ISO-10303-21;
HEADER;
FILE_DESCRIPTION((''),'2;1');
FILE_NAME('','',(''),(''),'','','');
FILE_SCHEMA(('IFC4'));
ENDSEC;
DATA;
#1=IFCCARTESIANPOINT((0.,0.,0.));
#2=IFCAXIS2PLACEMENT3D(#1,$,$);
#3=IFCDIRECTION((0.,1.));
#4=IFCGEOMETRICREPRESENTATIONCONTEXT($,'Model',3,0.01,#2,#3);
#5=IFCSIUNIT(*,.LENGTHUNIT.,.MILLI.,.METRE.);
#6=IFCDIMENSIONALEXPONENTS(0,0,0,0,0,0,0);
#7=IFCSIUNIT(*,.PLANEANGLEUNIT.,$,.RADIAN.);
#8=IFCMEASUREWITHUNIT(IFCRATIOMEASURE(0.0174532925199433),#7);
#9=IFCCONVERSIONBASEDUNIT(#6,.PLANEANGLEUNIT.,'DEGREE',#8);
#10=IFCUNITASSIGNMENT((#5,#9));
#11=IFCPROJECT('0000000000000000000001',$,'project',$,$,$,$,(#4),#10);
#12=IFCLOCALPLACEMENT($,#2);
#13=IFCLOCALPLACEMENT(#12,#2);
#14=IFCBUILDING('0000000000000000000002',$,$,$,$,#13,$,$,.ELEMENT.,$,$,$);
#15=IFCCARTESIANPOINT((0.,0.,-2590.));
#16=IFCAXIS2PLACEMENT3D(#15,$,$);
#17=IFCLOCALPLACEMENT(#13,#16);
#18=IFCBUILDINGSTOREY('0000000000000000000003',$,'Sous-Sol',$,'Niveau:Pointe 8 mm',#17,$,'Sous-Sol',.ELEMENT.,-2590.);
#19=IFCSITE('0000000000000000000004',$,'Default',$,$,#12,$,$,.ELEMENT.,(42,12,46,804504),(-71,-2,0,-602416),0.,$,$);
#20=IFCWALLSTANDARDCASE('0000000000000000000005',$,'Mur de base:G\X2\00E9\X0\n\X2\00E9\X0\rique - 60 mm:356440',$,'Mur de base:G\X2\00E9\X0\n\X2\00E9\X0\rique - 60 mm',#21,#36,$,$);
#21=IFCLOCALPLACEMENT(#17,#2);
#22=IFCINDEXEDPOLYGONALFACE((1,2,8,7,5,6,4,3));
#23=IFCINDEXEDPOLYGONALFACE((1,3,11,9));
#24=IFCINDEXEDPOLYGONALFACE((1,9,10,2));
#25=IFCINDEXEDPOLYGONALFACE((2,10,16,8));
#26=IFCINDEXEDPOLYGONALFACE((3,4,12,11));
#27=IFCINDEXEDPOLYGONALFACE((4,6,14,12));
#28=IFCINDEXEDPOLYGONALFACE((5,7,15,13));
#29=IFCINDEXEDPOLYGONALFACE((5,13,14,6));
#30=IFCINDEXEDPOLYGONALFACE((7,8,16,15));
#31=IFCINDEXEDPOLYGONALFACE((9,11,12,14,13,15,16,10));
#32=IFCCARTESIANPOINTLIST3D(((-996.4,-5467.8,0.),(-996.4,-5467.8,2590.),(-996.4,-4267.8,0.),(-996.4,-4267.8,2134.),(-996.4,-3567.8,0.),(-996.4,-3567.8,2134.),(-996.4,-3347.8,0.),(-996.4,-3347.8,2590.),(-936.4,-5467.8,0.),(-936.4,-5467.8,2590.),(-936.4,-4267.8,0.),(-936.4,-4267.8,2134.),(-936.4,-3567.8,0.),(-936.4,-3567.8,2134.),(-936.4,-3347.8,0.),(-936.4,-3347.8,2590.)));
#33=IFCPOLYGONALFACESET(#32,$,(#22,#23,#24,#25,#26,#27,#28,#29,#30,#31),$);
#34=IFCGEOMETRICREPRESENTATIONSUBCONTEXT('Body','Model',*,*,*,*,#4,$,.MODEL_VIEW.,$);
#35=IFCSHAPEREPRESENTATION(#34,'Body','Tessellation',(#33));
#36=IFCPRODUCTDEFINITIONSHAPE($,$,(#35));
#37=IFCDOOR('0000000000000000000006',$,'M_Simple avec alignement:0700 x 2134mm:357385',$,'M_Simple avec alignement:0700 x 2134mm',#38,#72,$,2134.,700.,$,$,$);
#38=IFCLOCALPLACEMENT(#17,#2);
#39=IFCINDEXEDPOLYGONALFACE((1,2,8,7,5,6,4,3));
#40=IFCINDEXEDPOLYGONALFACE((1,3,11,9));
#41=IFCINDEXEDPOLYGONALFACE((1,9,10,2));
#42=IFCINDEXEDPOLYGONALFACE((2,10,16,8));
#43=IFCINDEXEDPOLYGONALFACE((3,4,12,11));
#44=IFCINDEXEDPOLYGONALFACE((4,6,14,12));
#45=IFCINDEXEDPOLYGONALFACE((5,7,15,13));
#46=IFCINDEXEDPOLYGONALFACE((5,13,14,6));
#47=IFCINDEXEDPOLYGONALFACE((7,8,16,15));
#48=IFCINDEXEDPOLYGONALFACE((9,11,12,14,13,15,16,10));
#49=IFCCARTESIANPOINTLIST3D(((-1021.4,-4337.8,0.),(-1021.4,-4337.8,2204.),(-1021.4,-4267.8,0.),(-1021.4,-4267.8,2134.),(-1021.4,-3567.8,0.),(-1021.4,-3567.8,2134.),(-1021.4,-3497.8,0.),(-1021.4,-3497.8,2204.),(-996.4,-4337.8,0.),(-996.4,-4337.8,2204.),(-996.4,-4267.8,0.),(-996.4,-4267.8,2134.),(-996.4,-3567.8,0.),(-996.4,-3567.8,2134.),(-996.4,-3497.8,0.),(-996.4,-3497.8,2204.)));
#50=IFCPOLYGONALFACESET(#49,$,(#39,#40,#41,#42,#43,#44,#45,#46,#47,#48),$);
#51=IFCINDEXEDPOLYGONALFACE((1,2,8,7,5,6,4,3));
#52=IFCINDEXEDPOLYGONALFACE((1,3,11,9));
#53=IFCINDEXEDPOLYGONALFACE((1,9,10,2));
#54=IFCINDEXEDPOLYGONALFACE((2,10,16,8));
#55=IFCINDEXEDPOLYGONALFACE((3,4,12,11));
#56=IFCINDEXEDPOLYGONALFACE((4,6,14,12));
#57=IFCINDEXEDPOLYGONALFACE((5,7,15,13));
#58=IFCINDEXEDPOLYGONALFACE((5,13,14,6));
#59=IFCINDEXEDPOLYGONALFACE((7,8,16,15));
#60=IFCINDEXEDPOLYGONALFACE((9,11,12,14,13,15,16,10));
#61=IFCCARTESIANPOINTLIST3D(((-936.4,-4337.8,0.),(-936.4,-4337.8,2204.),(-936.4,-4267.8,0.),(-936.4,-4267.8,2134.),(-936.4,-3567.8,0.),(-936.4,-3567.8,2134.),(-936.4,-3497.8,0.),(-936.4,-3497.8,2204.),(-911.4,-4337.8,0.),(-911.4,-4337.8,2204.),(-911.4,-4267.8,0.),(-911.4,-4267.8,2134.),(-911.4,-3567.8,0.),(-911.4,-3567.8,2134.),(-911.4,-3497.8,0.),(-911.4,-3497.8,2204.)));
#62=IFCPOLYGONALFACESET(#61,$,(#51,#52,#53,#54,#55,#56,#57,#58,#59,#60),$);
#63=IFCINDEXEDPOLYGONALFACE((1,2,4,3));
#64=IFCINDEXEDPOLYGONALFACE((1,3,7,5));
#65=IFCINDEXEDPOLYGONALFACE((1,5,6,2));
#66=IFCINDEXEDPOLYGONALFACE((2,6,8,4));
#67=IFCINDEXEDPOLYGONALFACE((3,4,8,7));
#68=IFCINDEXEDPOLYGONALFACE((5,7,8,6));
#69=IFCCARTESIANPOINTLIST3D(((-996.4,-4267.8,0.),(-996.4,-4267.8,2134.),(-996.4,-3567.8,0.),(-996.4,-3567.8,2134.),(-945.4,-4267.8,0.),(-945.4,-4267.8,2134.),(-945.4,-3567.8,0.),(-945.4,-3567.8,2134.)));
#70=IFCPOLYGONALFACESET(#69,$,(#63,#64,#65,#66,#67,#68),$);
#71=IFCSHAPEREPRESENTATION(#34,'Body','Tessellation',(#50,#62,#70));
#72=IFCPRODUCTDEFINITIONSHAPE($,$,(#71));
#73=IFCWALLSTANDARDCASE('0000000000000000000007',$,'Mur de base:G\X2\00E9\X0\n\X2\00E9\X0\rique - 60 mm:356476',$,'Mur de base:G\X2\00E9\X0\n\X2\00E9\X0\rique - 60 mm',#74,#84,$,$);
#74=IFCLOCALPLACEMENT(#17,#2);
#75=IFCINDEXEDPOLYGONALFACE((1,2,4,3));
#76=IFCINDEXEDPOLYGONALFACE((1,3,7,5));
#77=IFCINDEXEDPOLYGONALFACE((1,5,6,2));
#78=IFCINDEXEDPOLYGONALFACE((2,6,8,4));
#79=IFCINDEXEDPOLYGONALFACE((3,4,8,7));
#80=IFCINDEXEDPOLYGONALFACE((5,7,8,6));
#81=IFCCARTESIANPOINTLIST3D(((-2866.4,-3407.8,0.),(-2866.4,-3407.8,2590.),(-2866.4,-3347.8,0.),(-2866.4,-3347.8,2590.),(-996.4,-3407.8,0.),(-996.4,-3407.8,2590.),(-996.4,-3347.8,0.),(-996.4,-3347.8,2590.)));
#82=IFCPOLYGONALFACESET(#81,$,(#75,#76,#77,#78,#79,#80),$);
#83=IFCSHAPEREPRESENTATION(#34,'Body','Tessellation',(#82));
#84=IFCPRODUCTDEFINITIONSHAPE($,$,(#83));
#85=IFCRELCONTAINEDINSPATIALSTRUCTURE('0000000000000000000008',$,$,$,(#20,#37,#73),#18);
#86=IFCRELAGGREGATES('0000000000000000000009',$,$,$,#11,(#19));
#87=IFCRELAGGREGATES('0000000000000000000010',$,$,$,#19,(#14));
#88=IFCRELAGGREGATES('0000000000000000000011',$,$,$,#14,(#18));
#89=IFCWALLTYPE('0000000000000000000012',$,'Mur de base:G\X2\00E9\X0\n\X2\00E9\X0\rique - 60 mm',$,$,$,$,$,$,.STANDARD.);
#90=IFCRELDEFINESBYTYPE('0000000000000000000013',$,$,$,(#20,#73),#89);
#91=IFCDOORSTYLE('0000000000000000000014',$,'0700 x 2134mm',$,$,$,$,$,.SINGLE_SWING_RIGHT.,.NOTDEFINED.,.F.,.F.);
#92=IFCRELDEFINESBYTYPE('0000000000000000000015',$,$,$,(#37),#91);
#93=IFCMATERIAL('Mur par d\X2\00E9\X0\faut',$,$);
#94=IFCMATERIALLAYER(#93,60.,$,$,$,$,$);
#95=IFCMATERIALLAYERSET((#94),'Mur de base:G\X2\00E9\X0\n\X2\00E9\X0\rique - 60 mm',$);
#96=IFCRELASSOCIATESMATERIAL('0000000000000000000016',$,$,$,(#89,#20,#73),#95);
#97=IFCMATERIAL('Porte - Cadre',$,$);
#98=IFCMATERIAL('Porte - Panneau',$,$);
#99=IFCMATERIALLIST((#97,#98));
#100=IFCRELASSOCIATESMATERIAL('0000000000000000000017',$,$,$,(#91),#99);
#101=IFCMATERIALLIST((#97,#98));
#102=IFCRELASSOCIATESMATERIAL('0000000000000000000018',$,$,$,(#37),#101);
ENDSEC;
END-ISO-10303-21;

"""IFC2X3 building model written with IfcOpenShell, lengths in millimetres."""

from ifc_helpers import new_model, entity, si_unit, converted_unit, direction, frame, frame_2d, origin, origin_2d_with_axis, place, context, subcontext, project, spatial, polyline, rectangle, outline, extrude, source, transform, mapped, material, material_list, layer, layer_set, layer_usage, type_object, type_shapes, element, fill, save


model = new_model("IFC2X3")

# Units and contexts
model_context = context("Model", 3, precision=0.01, world=origin(), true_north=direction((0.0, 1.0)))
body_context = subcontext(model_context, "Body", "Model", "MODEL_VIEW")
ifc_project = project(units=[si_unit("LENGTHUNIT", "METRE", prefix="MILLI"), converted_unit("PLANEANGLEUNIT", "DEGREE", entity("IfcRatioMeasure", 0.0174532925199433), si_unit("PLANEANGLEUNIT", "RADIAN"), dimensions=[0, 0, 0, 0, 0, 0, 0])], contexts=[model_context])

# Site, building, storey
site_placement = place(None, origin())
site = spatial("IfcSite", under=ifc_project, at=site_placement, Name="Default", CompositionType="ELEMENT", RefLatitude=(42, 12, 46, 804504), RefLongitude=(-71, -2, 0, -602416), RefElevation=0.0)
building_placement = place(site_placement, origin())
building = spatial("IfcBuilding", under=site, at=building_placement, CompositionType="ELEMENT")
storey_placement = place(building_placement, frame((0.0, 0.0, -2590.0)))
storey = spatial("IfcBuildingStorey", under=building, at=storey_placement, Name="Sous-Sol", ObjectType="Niveau:Pointe 8 mm", LongName="Sous-Sol", CompositionType="ELEMENT", Elevation=-2590.0)

# Shared definitions
ifc_material_1 = material(Name="Mur par défaut")

# Shared definitions
ifc_material_2 = material(Name="Porte - Cadre")
ifc_material_3 = material(Name="Porte - Panneau")

# Wall, opening, door
ifc_layer_1 = layer(ifc_material_1, 60.0)
ifc_layer_set_1 = layer_set([ifc_layer_1], Name="Mur de base:Générique - 60 mm")
ifc_layer_usage_1 = layer_usage(ifc_layer_set_1, "AXIS2", "NEGATIVE", 30.0)
wall_type_1 = type_object("IfcWallType", Name="Mur de base:Générique - 60 mm", PredefinedType="STANDARD", material=ifc_layer_set_1)
wall_1_placement = place(storey_placement, frame((-966.4, -5467.8, 0.0), z_axis=(0.0, 0.0, 1.0), x_axis=(0.0, 1.0, 0.0)))
wall_1 = element("IfcWallStandardCase", 1, at=wall_1_placement, inside=storey, type_object=wall_type_1, material=ifc_layer_usage_1, Name="Mur de base:Générique - 60 mm:356440", ObjectType="Mur de base:Générique - 60 mm", context=body_context, shape_type="SweptSolid", body=[
    extrude(rectangle(XDim=2120.0, YDim=60.0, at=frame_2d((1060.0, 0.0), x_axis=(-1.0, 0.0))), origin(), (0.0, 0.0, 1.0), 2590.0),
])
opening_1_placement = place(wall_1_placement, frame((1200.0, -30.0, 0.0)))
opening_1 = element("IfcOpeningElement", 2, at=opening_1_placement, cuts=wall_1, ObjectType="Opening", context=body_context, shape_type="SweptSolid", body=[
    extrude(rectangle(XDim=700.0, YDim=2134.0, at=frame_2d((1067.0, 350.0), x_axis=(0.0, 1.0))), frame((0.0, 0.0, 0.0), z_axis=(0.0, 1.0, 0.0), x_axis=(0.0, 0.0, 1.0)), (0.0, 0.0, 1.0), 60.0),
])
ifc_material_list_1 = material_list([ifc_material_2, ifc_material_3])
ifc_material_list_2 = material_list([ifc_material_2, ifc_material_3])
door_style_1 = type_object("IfcDoorStyle", Name="0700 x 2134mm", ConstructionType="NOTDEFINED", OperationType="SINGLE_SWING_RIGHT", ParameterTakesPrecedence=False, Sizeable=False, material=ifc_material_list_2)
shared_shape_1 = source(origin(), body_context, "Body", "SweptSolid", [
    extrude(outline(polyline([(-420.0, -1119.5), (420.0, -1119.5), (420.0, 1084.5), (350.0, 1084.5), (350.0, -1049.5), (-350.0, -1049.5), (-350.0, 1084.5), (-420.0, 1084.5), (-420.0, -1119.5)])), frame((350.0, 60.0, 1084.5), z_axis=(0.0, 1.0, 0.0), x_axis=(1.0, 0.0, 0.0)), (0.0, 0.0, 1.0), 25.0),
    extrude(outline(polyline([(-1119.5, -420.0), (1084.5, -420.0), (1084.5, -350.0), (-1049.5, -350.0), (-1049.5, 350.0), (1084.5, 350.0), (1084.5, 420.0), (-1119.5, 420.0), (-1119.5, -420.0)])), frame((350.0, -25.0, 1084.5), z_axis=(0.0, 1.0, 0.0), x_axis=(0.0, 0.0, -1.0)), (0.0, 0.0, 1.0), 25.0),
    extrude(rectangle(XDim=51.0, YDim=700.0, at=origin_2d_with_axis()), frame((350.0, 34.5, 0.0), z_axis=(0.0, 0.0, 1.0), x_axis=(0.0, 1.0, 0.0)), (0.0, 0.0, 1.0), 2134.0),
])
type_shapes(door_style_1, [shared_shape_1])
door_1_placement = place(opening_1_placement, origin())
door_1 = element("IfcDoor", 3, at=door_1_placement, inside=storey, type_object=door_style_1, material=ifc_material_list_1, Name="M_Simple avec alignement:0700 x 2134mm:357385", ObjectType="M_Simple avec alignement:0700 x 2134mm", OverallHeight=2134.0, OverallWidth=700.0, context=body_context, shape_type="MappedRepresentation", body=[
    mapped(shared_shape_1, transform((0.0, 0.0, 0.0), scale=1.0)),
])
fill(opening_1, door_1)

# Wall
ifc_layer_usage_2 = layer_usage(ifc_layer_set_1, "AXIS2", "NEGATIVE", 30.0)
wall_2_placement = place(storey_placement, frame((-996.4, -3377.8, 0.0), z_axis=(0.0, 0.0, 1.0), x_axis=(-1.0, 0.0, 0.0)))
element("IfcWallStandardCase", 4, at=wall_2_placement, inside=storey, type_object=wall_type_1, material=ifc_layer_usage_2, Name="Mur de base:Générique - 60 mm:356476", ObjectType="Mur de base:Générique - 60 mm", context=body_context, shape_type="SweptSolid", body=[
    extrude(rectangle(XDim=1870.0, YDim=60.0, at=frame_2d((935.0, 0.0), x_axis=(-1.0, 0.0))), origin(), (0.0, 0.0, 1.0), 2590.0),
])

save(model, "model.ifc")
